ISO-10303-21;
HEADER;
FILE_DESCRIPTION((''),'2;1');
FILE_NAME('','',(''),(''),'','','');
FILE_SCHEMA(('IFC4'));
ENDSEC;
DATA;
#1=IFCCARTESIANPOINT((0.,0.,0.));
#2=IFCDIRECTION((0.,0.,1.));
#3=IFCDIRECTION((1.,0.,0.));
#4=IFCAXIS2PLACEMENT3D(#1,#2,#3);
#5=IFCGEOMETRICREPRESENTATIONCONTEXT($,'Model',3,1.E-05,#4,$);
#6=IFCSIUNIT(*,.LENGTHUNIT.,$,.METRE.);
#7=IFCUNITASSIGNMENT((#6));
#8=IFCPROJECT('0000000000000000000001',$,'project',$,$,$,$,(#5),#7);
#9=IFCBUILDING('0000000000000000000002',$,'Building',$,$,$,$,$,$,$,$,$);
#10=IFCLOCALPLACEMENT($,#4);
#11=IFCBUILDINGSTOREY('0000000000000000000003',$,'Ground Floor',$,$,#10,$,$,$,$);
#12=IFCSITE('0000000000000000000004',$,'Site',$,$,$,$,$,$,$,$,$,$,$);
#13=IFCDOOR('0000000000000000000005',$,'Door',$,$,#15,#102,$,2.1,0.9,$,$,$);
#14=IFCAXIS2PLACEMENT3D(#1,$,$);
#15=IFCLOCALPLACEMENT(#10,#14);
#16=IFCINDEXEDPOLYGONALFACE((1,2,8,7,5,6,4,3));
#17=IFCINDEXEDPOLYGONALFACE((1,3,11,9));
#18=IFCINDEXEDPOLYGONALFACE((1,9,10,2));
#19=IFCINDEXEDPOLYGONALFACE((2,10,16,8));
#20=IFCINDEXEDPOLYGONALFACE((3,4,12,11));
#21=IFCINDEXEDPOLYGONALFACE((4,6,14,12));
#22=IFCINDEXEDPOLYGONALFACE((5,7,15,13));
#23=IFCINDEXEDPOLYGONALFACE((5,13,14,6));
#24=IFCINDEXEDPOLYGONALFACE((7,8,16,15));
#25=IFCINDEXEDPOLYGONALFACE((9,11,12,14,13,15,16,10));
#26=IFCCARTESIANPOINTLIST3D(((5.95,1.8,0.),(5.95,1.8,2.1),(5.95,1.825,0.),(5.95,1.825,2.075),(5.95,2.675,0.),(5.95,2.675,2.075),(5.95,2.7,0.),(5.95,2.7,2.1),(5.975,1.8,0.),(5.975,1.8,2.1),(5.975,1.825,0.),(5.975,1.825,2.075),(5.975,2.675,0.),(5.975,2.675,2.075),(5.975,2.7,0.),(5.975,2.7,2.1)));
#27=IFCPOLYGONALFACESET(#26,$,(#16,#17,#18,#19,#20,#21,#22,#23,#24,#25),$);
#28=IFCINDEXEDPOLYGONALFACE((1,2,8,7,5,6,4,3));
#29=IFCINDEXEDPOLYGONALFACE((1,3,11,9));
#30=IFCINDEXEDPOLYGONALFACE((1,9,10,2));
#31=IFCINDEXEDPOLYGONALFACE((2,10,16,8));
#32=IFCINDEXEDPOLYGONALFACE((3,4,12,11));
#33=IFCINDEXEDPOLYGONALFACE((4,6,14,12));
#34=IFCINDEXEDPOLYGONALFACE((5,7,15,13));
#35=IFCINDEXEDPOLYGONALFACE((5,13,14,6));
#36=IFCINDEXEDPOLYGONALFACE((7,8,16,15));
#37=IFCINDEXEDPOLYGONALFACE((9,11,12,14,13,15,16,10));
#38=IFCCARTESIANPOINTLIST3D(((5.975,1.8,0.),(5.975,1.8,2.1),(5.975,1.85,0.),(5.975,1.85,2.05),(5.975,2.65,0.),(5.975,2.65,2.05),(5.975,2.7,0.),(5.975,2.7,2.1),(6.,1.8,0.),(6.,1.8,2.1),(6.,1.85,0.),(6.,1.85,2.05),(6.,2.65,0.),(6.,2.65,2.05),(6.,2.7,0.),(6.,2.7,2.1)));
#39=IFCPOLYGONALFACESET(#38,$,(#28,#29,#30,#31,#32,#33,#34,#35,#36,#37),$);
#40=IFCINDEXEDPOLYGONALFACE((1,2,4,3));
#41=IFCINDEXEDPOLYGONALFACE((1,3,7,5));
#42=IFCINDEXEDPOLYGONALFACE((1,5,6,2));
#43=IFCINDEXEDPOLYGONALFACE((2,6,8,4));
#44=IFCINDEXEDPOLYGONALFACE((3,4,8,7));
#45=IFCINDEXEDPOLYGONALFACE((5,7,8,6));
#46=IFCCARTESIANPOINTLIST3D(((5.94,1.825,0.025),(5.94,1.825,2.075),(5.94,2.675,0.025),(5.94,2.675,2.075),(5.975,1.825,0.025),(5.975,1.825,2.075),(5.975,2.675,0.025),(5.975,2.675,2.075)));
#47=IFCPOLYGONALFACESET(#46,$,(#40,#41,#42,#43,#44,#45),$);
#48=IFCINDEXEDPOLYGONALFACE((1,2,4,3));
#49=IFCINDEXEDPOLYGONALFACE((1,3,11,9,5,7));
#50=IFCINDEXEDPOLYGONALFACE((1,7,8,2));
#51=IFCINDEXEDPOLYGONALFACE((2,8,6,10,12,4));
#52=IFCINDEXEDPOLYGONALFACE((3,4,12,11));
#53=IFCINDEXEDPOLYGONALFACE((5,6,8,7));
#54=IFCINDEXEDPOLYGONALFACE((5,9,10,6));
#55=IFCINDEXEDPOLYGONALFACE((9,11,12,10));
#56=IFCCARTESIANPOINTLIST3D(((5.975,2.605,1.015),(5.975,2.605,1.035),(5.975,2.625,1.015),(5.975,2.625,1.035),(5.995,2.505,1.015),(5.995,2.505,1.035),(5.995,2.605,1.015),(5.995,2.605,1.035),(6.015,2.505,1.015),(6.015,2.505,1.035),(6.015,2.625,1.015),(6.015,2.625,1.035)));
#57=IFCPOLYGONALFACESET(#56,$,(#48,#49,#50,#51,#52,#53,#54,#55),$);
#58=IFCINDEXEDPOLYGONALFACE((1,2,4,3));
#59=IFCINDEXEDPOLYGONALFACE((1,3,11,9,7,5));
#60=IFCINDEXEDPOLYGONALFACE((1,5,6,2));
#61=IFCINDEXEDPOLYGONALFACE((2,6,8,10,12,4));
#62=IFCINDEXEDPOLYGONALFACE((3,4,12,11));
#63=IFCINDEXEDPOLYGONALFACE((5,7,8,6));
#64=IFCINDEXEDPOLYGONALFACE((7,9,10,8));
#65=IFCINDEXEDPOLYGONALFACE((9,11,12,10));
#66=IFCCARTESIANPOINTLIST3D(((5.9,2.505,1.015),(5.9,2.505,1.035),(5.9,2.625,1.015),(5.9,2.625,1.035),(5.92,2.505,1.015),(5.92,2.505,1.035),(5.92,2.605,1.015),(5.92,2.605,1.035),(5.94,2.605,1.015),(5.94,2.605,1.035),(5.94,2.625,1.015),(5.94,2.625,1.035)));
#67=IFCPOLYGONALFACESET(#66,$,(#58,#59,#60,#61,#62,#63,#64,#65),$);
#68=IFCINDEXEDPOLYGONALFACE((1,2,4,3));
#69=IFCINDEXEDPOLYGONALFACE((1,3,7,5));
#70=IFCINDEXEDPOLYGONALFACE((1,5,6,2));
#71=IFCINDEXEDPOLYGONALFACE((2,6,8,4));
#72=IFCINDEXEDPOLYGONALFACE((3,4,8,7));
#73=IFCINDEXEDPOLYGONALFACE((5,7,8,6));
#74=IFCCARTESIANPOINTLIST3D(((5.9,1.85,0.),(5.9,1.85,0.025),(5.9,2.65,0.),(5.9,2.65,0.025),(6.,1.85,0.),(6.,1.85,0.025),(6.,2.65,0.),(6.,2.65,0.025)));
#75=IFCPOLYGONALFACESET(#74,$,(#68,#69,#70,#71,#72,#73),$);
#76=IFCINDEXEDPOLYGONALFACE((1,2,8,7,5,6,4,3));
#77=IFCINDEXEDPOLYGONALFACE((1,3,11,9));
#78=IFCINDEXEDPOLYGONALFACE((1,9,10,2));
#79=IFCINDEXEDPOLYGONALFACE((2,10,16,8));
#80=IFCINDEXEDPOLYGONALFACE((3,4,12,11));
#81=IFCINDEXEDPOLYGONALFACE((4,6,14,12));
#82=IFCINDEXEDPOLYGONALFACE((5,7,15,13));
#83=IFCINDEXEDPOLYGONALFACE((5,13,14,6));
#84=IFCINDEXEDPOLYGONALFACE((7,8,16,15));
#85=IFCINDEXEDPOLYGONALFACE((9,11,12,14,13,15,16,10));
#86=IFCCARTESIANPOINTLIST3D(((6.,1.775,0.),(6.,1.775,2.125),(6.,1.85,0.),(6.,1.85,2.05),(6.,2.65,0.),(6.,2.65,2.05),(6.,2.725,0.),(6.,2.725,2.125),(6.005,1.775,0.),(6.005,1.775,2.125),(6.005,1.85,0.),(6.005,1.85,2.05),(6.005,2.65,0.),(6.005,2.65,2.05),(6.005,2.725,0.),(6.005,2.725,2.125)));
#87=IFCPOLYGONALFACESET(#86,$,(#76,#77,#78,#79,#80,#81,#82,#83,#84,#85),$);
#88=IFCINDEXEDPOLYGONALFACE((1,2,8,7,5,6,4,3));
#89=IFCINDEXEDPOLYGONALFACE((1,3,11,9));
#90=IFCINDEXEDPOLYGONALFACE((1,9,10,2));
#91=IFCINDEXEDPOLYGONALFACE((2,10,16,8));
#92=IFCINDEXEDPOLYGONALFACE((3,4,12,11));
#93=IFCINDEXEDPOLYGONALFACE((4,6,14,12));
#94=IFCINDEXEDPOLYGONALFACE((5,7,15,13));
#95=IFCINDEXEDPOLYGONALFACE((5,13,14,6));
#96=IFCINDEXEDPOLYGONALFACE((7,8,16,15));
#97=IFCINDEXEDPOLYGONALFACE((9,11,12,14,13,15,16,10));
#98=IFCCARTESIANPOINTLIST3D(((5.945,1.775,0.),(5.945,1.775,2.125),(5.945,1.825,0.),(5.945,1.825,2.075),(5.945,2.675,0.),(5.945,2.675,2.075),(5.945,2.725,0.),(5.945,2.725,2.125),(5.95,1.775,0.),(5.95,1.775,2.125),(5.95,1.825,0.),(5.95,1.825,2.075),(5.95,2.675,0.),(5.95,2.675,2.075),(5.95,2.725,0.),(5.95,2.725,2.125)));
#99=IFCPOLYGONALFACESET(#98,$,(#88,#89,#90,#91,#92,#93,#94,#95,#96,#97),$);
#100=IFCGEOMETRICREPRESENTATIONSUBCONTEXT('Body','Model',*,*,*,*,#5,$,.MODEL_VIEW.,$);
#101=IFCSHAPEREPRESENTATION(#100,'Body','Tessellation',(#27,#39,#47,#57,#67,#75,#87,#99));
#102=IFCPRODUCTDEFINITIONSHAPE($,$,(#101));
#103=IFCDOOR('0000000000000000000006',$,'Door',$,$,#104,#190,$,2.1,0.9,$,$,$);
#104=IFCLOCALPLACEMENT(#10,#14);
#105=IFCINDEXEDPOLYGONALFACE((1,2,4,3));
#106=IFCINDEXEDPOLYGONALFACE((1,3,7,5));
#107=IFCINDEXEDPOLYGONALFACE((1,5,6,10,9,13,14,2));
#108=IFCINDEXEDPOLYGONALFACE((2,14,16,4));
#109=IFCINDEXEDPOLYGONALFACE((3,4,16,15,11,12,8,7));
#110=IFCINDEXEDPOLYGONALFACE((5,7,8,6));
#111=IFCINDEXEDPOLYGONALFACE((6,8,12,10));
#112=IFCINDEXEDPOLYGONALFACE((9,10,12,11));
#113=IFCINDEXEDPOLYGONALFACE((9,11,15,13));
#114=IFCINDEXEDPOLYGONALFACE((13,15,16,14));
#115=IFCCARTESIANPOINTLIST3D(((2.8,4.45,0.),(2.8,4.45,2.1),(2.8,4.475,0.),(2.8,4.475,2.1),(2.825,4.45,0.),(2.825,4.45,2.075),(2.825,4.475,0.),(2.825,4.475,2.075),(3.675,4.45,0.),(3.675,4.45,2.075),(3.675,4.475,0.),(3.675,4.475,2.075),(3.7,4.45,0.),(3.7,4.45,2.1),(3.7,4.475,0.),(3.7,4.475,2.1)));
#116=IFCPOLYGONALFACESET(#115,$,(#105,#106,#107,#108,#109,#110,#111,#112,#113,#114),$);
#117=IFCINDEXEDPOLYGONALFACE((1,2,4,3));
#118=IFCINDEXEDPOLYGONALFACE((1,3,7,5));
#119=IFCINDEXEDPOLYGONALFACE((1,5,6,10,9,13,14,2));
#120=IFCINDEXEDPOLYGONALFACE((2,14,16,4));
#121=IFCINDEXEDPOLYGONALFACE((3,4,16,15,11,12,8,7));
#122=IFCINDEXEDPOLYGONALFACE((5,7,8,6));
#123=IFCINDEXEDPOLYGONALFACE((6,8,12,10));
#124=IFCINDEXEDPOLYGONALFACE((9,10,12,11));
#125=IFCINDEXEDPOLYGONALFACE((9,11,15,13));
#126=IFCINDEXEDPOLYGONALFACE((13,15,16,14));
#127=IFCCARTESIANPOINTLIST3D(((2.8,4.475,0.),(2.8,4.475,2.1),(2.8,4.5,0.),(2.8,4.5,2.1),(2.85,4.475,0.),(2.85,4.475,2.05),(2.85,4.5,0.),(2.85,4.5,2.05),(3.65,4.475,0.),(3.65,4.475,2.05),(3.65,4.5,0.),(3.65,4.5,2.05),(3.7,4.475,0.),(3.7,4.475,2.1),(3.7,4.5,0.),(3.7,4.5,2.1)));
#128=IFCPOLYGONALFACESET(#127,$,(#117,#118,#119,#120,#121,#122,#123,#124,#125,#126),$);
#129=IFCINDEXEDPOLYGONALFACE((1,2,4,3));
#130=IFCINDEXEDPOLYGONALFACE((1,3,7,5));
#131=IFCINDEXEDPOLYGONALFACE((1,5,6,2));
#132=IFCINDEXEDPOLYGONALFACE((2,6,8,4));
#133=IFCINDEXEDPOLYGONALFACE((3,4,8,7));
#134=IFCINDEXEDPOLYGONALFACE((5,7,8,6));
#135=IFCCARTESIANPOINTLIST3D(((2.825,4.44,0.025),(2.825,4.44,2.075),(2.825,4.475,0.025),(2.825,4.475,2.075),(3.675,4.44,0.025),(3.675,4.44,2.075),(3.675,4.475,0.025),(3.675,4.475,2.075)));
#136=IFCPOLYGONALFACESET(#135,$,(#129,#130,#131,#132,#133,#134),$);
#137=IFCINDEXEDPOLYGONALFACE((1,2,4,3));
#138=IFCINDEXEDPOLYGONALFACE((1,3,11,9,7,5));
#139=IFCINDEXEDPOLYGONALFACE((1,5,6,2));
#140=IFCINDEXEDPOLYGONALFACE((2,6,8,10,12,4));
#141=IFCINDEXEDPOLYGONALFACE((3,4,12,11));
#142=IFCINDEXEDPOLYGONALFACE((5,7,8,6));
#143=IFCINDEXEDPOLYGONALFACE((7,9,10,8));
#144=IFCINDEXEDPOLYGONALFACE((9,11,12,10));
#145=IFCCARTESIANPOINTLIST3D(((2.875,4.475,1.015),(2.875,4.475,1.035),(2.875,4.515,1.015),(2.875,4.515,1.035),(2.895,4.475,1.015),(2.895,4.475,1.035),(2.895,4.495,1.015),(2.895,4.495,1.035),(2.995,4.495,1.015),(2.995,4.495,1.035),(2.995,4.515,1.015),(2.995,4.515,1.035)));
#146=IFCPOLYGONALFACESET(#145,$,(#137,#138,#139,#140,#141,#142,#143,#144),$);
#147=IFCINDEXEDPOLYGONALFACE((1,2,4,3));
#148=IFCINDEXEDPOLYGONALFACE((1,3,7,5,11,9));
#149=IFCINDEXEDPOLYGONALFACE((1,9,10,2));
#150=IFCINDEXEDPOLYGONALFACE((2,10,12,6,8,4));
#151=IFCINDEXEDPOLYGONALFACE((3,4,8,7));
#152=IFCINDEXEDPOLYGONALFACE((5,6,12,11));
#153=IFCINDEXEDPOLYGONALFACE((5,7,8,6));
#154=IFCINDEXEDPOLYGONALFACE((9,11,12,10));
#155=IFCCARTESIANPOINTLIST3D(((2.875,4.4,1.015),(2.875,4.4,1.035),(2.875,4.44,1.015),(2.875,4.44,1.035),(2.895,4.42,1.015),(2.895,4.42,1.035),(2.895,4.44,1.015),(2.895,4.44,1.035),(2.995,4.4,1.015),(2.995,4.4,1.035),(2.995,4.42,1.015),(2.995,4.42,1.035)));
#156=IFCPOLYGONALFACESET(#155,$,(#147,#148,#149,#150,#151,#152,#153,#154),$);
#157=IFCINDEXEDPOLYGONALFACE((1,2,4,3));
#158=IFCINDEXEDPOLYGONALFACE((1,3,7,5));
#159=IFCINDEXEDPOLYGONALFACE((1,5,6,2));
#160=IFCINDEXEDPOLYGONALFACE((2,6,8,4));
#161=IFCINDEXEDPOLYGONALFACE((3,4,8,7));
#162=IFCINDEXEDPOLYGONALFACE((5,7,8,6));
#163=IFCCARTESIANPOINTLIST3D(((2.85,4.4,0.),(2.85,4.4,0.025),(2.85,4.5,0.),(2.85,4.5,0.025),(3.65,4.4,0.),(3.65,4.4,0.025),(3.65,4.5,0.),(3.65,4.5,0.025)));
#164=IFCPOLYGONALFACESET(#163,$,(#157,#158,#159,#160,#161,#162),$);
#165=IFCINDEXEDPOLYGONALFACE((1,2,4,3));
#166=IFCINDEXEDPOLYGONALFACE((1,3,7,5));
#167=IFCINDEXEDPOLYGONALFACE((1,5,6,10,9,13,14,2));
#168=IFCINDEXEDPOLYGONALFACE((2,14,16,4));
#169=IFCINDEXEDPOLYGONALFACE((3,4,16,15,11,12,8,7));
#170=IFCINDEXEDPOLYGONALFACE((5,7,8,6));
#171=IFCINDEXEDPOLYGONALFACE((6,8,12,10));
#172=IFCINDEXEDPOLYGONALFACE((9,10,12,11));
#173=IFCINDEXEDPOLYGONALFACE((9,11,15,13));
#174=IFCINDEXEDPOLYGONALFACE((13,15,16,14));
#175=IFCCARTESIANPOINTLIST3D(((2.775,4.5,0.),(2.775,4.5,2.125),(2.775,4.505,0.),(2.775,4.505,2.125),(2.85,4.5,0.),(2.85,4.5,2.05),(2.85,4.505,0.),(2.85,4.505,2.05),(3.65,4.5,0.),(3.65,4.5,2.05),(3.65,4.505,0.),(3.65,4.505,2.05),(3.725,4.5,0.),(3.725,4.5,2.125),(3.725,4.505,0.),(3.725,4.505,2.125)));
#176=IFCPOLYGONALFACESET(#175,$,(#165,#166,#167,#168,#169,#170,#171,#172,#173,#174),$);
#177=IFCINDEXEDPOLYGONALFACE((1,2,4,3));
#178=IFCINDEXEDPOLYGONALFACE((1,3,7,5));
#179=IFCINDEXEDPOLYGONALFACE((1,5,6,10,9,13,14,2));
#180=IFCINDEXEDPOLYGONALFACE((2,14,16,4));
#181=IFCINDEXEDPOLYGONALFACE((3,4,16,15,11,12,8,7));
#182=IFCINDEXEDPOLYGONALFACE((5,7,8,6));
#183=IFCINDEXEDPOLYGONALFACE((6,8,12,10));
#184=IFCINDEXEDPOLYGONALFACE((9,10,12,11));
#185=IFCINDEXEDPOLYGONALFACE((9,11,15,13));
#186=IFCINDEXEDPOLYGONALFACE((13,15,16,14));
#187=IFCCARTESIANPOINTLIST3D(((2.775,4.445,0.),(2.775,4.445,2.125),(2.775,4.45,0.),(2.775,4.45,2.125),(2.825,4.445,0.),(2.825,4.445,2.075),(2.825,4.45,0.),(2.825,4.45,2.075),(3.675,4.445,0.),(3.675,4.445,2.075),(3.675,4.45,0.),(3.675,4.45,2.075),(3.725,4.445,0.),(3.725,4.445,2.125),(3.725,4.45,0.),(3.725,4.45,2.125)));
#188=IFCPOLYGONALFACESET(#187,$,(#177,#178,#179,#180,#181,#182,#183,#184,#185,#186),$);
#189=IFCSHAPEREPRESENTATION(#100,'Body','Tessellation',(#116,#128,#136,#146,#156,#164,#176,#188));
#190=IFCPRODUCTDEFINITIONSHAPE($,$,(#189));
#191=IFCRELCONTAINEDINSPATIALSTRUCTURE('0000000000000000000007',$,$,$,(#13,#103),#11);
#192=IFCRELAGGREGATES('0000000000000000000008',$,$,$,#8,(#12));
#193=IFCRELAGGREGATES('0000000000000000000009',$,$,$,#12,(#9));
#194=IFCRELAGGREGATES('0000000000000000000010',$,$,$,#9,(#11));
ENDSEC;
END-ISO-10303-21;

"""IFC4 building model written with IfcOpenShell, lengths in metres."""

from ifc_helpers import new_model, si_unit, frame, origin_with_axes, place, context, subcontext, project, spatial, line, indexed_curve, outline, extrude, element, save


model = new_model("IFC4")

# Units and contexts
model_context = context("Model", 3, precision=1e-05, world=origin_with_axes())
body_context = subcontext(model_context, "Body", "Model", "MODEL_VIEW")
ifc_project = project(units=[si_unit("LENGTHUNIT", "METRE")], contexts=[model_context])

# Site, building, storey
site = spatial("IfcSite", under=ifc_project, Name="Site")
building = spatial("IfcBuilding", under=site, Name="Building")
storey_placement = place(None, origin_with_axes())
storey = spatial("IfcBuildingStorey", under=building, at=storey_placement, Name="Ground Floor")

# Doors
door_1_placement = place(storey_placement, frame((6.0, 1.8, 0.0), z_axis=(0.0, 0.0, 1.0), x_axis=(0.0, 1.0, 0.0)))
element("IfcDoor", 1, at=door_1_placement, inside=storey, Name="Door", OverallHeight=2.1, OverallWidth=0.9, context=body_context, shape_type="SweptSolid", body=[
    extrude(outline(indexed_curve([(0.0, 0.0), (0.0, 2.1), (0.9, 2.1), (0.9, 0.0), (0.875, 0.0), (0.875, 2.075), (0.025, 2.075), (0.025, 0.0)], segments=[line(1, 2, 3, 4, 5, 6, 7, 8, 1)])), frame((0.0, 0.025, 0.0), z_axis=(0.0, -1.0, 0.0), x_axis=(1.0, 0.0, 0.0)), (0.0, 0.0, -1.0), 0.025),
    extrude(outline(indexed_curve([(0.0, 0.0), (0.0, 2.1), (0.9, 2.1), (0.9, 0.0), (0.85, 0.0), (0.85, 2.05), (0.05, 2.05), (0.05, 0.0)], segments=[line(1, 2, 3, 4, 5, 6, 7, 8, 1)])), frame((0.0, 0.0, 0.0), z_axis=(0.0, -1.0, 0.0), x_axis=(1.0, 0.0, 0.0)), (0.0, 0.0, -1.0), 0.025),
    extrude(outline(indexed_curve([(0.0, 0.0), (0.85, 0.0), (0.85, 0.035), (0.0, 0.035)], segments=[line(1, 2, 3, 4, 1)])), frame((0.025, 0.025, 0.025), z_axis=(0.0, 0.0, 1.0), x_axis=(1.0, 0.0, 0.0)), (0.0, 0.0, 1.0), 2.05),
    extrude(outline(indexed_curve([(0.0, 0.0), (0.0, -0.04), (-0.12, -0.04), (-0.12, -0.02), (-0.02, -0.02), (-0.02, 0.0)], segments=[line(1, 2, 3, 4, 5, 6, 1)])), frame((0.825, 0.025, 1.015), z_axis=(0.0, 0.0, 1.0), x_axis=(1.0, 0.0, 0.0)), (0.0, 0.0, 1.0), 0.02),
    extrude(outline(indexed_curve([(0.0, 0.0), (0.0, 0.04), (-0.12, 0.04), (-0.12, 0.02), (-0.02, 0.02), (-0.02, 0.0)], segments=[line(1, 2, 3, 4, 5, 6, 1)])), frame((0.825, 0.06, 1.015), z_axis=(0.0, 0.0, 1.0), x_axis=(1.0, 0.0, 0.0)), (0.0, 0.0, 1.0), 0.02),
    extrude(outline(indexed_curve([(0.0, 0.0), (0.8, 0.0), (0.8, 0.1), (0.0, 0.1)], segments=[line(1, 2, 3, 4, 1)])), frame((0.05, 0.0, 0.0), z_axis=(0.0, 0.0, 1.0), x_axis=(1.0, 0.0, 0.0)), (0.0, 0.0, 1.0), 0.025),
    extrude(outline(indexed_curve([(0.0, 0.0), (0.0, 2.125), (0.95, 2.125), (0.95, 0.0), (0.875, 0.0), (0.875, 2.05), (0.075, 2.05), (0.075, 0.0)], segments=[line(1, 2, 3, 4, 5, 6, 7, 8, 1)])), frame((-0.025, -0.005, 0.0), z_axis=(0.0, -1.0, 0.0), x_axis=(1.0, 0.0, 0.0)), (0.0, 0.0, -1.0), 0.005),
    extrude(outline(indexed_curve([(0.0, 0.0), (0.0, 2.125), (0.95, 2.125), (0.95, 0.0), (0.9, 0.0), (0.9, 2.075), (0.05, 2.075), (0.05, 0.0)], segments=[line(1, 2, 3, 4, 5, 6, 7, 8, 1)])), frame((-0.025, 0.05, 0.0), z_axis=(0.0, -1.0, 0.0), x_axis=(1.0, 0.0, 0.0)), (0.0, 0.0, -1.0), 0.005),
])
door_2_placement = place(storey_placement, frame((3.7, 4.5, 0.0), z_axis=(0.0, 0.0, 1.0), x_axis=(-1.0, 0.0, 0.0)))
element("IfcDoor", 2, at=door_2_placement, inside=storey, Name="Door", OverallHeight=2.1, OverallWidth=0.9, context=body_context, shape_type="SweptSolid", body=[
    extrude(outline(indexed_curve([(0.0, 0.0), (0.0, 2.1), (0.9, 2.1), (0.9, 0.0), (0.875, 0.0), (0.875, 2.075), (0.025, 2.075), (0.025, 0.0)], segments=[line(1, 2, 3, 4, 5, 6, 7, 8, 1)])), frame((0.0, 0.025, 0.0), z_axis=(0.0, -1.0, 0.0), x_axis=(1.0, 0.0, 0.0)), (0.0, 0.0, -1.0), 0.025),
    extrude(outline(indexed_curve([(0.0, 0.0), (0.0, 2.1), (0.9, 2.1), (0.9, 0.0), (0.85, 0.0), (0.85, 2.05), (0.05, 2.05), (0.05, 0.0)], segments=[line(1, 2, 3, 4, 5, 6, 7, 8, 1)])), frame((0.0, 0.0, 0.0), z_axis=(0.0, -1.0, 0.0), x_axis=(1.0, 0.0, 0.0)), (0.0, 0.0, -1.0), 0.025),
    extrude(outline(indexed_curve([(0.0, 0.0), (0.85, 0.0), (0.85, 0.035), (0.0, 0.035)], segments=[line(1, 2, 3, 4, 1)])), frame((0.025, 0.025, 0.025), z_axis=(0.0, 0.0, 1.0), x_axis=(1.0, 0.0, 0.0)), (0.0, 0.0, 1.0), 2.05),
    extrude(outline(indexed_curve([(0.0, 0.0), (0.0, -0.04), (-0.12, -0.04), (-0.12, -0.02), (-0.02, -0.02), (-0.02, 0.0)], segments=[line(1, 2, 3, 4, 5, 6, 1)])), frame((0.825, 0.025, 1.015), z_axis=(0.0, 0.0, 1.0), x_axis=(1.0, 0.0, 0.0)), (0.0, 0.0, 1.0), 0.02),
    extrude(outline(indexed_curve([(0.0, 0.0), (0.0, 0.04), (-0.12, 0.04), (-0.12, 0.02), (-0.02, 0.02), (-0.02, 0.0)], segments=[line(1, 2, 3, 4, 5, 6, 1)])), frame((0.825, 0.06, 1.015), z_axis=(0.0, 0.0, 1.0), x_axis=(1.0, 0.0, 0.0)), (0.0, 0.0, 1.0), 0.02),
    extrude(outline(indexed_curve([(0.0, 0.0), (0.8, 0.0), (0.8, 0.1), (0.0, 0.1)], segments=[line(1, 2, 3, 4, 1)])), frame((0.05, 0.0, 0.0), z_axis=(0.0, 0.0, 1.0), x_axis=(1.0, 0.0, 0.0)), (0.0, 0.0, 1.0), 0.025),
    extrude(outline(indexed_curve([(0.0, 0.0), (0.0, 2.125), (0.95, 2.125), (0.95, 0.0), (0.875, 0.0), (0.875, 2.05), (0.075, 2.05), (0.075, 0.0)], segments=[line(1, 2, 3, 4, 5, 6, 7, 8, 1)])), frame((-0.025, -0.005, 0.0), z_axis=(0.0, -1.0, 0.0), x_axis=(1.0, 0.0, 0.0)), (0.0, 0.0, -1.0), 0.005),
    extrude(outline(indexed_curve([(0.0, 0.0), (0.0, 2.125), (0.95, 2.125), (0.95, 0.0), (0.9, 0.0), (0.9, 2.075), (0.05, 2.075), (0.05, 0.0)], segments=[line(1, 2, 3, 4, 5, 6, 7, 8, 1)])), frame((-0.025, 0.05, 0.0), z_axis=(0.0, -1.0, 0.0), x_axis=(1.0, 0.0, 0.0)), (0.0, 0.0, -1.0), 0.005),
])

save(model, "model.ifc")
